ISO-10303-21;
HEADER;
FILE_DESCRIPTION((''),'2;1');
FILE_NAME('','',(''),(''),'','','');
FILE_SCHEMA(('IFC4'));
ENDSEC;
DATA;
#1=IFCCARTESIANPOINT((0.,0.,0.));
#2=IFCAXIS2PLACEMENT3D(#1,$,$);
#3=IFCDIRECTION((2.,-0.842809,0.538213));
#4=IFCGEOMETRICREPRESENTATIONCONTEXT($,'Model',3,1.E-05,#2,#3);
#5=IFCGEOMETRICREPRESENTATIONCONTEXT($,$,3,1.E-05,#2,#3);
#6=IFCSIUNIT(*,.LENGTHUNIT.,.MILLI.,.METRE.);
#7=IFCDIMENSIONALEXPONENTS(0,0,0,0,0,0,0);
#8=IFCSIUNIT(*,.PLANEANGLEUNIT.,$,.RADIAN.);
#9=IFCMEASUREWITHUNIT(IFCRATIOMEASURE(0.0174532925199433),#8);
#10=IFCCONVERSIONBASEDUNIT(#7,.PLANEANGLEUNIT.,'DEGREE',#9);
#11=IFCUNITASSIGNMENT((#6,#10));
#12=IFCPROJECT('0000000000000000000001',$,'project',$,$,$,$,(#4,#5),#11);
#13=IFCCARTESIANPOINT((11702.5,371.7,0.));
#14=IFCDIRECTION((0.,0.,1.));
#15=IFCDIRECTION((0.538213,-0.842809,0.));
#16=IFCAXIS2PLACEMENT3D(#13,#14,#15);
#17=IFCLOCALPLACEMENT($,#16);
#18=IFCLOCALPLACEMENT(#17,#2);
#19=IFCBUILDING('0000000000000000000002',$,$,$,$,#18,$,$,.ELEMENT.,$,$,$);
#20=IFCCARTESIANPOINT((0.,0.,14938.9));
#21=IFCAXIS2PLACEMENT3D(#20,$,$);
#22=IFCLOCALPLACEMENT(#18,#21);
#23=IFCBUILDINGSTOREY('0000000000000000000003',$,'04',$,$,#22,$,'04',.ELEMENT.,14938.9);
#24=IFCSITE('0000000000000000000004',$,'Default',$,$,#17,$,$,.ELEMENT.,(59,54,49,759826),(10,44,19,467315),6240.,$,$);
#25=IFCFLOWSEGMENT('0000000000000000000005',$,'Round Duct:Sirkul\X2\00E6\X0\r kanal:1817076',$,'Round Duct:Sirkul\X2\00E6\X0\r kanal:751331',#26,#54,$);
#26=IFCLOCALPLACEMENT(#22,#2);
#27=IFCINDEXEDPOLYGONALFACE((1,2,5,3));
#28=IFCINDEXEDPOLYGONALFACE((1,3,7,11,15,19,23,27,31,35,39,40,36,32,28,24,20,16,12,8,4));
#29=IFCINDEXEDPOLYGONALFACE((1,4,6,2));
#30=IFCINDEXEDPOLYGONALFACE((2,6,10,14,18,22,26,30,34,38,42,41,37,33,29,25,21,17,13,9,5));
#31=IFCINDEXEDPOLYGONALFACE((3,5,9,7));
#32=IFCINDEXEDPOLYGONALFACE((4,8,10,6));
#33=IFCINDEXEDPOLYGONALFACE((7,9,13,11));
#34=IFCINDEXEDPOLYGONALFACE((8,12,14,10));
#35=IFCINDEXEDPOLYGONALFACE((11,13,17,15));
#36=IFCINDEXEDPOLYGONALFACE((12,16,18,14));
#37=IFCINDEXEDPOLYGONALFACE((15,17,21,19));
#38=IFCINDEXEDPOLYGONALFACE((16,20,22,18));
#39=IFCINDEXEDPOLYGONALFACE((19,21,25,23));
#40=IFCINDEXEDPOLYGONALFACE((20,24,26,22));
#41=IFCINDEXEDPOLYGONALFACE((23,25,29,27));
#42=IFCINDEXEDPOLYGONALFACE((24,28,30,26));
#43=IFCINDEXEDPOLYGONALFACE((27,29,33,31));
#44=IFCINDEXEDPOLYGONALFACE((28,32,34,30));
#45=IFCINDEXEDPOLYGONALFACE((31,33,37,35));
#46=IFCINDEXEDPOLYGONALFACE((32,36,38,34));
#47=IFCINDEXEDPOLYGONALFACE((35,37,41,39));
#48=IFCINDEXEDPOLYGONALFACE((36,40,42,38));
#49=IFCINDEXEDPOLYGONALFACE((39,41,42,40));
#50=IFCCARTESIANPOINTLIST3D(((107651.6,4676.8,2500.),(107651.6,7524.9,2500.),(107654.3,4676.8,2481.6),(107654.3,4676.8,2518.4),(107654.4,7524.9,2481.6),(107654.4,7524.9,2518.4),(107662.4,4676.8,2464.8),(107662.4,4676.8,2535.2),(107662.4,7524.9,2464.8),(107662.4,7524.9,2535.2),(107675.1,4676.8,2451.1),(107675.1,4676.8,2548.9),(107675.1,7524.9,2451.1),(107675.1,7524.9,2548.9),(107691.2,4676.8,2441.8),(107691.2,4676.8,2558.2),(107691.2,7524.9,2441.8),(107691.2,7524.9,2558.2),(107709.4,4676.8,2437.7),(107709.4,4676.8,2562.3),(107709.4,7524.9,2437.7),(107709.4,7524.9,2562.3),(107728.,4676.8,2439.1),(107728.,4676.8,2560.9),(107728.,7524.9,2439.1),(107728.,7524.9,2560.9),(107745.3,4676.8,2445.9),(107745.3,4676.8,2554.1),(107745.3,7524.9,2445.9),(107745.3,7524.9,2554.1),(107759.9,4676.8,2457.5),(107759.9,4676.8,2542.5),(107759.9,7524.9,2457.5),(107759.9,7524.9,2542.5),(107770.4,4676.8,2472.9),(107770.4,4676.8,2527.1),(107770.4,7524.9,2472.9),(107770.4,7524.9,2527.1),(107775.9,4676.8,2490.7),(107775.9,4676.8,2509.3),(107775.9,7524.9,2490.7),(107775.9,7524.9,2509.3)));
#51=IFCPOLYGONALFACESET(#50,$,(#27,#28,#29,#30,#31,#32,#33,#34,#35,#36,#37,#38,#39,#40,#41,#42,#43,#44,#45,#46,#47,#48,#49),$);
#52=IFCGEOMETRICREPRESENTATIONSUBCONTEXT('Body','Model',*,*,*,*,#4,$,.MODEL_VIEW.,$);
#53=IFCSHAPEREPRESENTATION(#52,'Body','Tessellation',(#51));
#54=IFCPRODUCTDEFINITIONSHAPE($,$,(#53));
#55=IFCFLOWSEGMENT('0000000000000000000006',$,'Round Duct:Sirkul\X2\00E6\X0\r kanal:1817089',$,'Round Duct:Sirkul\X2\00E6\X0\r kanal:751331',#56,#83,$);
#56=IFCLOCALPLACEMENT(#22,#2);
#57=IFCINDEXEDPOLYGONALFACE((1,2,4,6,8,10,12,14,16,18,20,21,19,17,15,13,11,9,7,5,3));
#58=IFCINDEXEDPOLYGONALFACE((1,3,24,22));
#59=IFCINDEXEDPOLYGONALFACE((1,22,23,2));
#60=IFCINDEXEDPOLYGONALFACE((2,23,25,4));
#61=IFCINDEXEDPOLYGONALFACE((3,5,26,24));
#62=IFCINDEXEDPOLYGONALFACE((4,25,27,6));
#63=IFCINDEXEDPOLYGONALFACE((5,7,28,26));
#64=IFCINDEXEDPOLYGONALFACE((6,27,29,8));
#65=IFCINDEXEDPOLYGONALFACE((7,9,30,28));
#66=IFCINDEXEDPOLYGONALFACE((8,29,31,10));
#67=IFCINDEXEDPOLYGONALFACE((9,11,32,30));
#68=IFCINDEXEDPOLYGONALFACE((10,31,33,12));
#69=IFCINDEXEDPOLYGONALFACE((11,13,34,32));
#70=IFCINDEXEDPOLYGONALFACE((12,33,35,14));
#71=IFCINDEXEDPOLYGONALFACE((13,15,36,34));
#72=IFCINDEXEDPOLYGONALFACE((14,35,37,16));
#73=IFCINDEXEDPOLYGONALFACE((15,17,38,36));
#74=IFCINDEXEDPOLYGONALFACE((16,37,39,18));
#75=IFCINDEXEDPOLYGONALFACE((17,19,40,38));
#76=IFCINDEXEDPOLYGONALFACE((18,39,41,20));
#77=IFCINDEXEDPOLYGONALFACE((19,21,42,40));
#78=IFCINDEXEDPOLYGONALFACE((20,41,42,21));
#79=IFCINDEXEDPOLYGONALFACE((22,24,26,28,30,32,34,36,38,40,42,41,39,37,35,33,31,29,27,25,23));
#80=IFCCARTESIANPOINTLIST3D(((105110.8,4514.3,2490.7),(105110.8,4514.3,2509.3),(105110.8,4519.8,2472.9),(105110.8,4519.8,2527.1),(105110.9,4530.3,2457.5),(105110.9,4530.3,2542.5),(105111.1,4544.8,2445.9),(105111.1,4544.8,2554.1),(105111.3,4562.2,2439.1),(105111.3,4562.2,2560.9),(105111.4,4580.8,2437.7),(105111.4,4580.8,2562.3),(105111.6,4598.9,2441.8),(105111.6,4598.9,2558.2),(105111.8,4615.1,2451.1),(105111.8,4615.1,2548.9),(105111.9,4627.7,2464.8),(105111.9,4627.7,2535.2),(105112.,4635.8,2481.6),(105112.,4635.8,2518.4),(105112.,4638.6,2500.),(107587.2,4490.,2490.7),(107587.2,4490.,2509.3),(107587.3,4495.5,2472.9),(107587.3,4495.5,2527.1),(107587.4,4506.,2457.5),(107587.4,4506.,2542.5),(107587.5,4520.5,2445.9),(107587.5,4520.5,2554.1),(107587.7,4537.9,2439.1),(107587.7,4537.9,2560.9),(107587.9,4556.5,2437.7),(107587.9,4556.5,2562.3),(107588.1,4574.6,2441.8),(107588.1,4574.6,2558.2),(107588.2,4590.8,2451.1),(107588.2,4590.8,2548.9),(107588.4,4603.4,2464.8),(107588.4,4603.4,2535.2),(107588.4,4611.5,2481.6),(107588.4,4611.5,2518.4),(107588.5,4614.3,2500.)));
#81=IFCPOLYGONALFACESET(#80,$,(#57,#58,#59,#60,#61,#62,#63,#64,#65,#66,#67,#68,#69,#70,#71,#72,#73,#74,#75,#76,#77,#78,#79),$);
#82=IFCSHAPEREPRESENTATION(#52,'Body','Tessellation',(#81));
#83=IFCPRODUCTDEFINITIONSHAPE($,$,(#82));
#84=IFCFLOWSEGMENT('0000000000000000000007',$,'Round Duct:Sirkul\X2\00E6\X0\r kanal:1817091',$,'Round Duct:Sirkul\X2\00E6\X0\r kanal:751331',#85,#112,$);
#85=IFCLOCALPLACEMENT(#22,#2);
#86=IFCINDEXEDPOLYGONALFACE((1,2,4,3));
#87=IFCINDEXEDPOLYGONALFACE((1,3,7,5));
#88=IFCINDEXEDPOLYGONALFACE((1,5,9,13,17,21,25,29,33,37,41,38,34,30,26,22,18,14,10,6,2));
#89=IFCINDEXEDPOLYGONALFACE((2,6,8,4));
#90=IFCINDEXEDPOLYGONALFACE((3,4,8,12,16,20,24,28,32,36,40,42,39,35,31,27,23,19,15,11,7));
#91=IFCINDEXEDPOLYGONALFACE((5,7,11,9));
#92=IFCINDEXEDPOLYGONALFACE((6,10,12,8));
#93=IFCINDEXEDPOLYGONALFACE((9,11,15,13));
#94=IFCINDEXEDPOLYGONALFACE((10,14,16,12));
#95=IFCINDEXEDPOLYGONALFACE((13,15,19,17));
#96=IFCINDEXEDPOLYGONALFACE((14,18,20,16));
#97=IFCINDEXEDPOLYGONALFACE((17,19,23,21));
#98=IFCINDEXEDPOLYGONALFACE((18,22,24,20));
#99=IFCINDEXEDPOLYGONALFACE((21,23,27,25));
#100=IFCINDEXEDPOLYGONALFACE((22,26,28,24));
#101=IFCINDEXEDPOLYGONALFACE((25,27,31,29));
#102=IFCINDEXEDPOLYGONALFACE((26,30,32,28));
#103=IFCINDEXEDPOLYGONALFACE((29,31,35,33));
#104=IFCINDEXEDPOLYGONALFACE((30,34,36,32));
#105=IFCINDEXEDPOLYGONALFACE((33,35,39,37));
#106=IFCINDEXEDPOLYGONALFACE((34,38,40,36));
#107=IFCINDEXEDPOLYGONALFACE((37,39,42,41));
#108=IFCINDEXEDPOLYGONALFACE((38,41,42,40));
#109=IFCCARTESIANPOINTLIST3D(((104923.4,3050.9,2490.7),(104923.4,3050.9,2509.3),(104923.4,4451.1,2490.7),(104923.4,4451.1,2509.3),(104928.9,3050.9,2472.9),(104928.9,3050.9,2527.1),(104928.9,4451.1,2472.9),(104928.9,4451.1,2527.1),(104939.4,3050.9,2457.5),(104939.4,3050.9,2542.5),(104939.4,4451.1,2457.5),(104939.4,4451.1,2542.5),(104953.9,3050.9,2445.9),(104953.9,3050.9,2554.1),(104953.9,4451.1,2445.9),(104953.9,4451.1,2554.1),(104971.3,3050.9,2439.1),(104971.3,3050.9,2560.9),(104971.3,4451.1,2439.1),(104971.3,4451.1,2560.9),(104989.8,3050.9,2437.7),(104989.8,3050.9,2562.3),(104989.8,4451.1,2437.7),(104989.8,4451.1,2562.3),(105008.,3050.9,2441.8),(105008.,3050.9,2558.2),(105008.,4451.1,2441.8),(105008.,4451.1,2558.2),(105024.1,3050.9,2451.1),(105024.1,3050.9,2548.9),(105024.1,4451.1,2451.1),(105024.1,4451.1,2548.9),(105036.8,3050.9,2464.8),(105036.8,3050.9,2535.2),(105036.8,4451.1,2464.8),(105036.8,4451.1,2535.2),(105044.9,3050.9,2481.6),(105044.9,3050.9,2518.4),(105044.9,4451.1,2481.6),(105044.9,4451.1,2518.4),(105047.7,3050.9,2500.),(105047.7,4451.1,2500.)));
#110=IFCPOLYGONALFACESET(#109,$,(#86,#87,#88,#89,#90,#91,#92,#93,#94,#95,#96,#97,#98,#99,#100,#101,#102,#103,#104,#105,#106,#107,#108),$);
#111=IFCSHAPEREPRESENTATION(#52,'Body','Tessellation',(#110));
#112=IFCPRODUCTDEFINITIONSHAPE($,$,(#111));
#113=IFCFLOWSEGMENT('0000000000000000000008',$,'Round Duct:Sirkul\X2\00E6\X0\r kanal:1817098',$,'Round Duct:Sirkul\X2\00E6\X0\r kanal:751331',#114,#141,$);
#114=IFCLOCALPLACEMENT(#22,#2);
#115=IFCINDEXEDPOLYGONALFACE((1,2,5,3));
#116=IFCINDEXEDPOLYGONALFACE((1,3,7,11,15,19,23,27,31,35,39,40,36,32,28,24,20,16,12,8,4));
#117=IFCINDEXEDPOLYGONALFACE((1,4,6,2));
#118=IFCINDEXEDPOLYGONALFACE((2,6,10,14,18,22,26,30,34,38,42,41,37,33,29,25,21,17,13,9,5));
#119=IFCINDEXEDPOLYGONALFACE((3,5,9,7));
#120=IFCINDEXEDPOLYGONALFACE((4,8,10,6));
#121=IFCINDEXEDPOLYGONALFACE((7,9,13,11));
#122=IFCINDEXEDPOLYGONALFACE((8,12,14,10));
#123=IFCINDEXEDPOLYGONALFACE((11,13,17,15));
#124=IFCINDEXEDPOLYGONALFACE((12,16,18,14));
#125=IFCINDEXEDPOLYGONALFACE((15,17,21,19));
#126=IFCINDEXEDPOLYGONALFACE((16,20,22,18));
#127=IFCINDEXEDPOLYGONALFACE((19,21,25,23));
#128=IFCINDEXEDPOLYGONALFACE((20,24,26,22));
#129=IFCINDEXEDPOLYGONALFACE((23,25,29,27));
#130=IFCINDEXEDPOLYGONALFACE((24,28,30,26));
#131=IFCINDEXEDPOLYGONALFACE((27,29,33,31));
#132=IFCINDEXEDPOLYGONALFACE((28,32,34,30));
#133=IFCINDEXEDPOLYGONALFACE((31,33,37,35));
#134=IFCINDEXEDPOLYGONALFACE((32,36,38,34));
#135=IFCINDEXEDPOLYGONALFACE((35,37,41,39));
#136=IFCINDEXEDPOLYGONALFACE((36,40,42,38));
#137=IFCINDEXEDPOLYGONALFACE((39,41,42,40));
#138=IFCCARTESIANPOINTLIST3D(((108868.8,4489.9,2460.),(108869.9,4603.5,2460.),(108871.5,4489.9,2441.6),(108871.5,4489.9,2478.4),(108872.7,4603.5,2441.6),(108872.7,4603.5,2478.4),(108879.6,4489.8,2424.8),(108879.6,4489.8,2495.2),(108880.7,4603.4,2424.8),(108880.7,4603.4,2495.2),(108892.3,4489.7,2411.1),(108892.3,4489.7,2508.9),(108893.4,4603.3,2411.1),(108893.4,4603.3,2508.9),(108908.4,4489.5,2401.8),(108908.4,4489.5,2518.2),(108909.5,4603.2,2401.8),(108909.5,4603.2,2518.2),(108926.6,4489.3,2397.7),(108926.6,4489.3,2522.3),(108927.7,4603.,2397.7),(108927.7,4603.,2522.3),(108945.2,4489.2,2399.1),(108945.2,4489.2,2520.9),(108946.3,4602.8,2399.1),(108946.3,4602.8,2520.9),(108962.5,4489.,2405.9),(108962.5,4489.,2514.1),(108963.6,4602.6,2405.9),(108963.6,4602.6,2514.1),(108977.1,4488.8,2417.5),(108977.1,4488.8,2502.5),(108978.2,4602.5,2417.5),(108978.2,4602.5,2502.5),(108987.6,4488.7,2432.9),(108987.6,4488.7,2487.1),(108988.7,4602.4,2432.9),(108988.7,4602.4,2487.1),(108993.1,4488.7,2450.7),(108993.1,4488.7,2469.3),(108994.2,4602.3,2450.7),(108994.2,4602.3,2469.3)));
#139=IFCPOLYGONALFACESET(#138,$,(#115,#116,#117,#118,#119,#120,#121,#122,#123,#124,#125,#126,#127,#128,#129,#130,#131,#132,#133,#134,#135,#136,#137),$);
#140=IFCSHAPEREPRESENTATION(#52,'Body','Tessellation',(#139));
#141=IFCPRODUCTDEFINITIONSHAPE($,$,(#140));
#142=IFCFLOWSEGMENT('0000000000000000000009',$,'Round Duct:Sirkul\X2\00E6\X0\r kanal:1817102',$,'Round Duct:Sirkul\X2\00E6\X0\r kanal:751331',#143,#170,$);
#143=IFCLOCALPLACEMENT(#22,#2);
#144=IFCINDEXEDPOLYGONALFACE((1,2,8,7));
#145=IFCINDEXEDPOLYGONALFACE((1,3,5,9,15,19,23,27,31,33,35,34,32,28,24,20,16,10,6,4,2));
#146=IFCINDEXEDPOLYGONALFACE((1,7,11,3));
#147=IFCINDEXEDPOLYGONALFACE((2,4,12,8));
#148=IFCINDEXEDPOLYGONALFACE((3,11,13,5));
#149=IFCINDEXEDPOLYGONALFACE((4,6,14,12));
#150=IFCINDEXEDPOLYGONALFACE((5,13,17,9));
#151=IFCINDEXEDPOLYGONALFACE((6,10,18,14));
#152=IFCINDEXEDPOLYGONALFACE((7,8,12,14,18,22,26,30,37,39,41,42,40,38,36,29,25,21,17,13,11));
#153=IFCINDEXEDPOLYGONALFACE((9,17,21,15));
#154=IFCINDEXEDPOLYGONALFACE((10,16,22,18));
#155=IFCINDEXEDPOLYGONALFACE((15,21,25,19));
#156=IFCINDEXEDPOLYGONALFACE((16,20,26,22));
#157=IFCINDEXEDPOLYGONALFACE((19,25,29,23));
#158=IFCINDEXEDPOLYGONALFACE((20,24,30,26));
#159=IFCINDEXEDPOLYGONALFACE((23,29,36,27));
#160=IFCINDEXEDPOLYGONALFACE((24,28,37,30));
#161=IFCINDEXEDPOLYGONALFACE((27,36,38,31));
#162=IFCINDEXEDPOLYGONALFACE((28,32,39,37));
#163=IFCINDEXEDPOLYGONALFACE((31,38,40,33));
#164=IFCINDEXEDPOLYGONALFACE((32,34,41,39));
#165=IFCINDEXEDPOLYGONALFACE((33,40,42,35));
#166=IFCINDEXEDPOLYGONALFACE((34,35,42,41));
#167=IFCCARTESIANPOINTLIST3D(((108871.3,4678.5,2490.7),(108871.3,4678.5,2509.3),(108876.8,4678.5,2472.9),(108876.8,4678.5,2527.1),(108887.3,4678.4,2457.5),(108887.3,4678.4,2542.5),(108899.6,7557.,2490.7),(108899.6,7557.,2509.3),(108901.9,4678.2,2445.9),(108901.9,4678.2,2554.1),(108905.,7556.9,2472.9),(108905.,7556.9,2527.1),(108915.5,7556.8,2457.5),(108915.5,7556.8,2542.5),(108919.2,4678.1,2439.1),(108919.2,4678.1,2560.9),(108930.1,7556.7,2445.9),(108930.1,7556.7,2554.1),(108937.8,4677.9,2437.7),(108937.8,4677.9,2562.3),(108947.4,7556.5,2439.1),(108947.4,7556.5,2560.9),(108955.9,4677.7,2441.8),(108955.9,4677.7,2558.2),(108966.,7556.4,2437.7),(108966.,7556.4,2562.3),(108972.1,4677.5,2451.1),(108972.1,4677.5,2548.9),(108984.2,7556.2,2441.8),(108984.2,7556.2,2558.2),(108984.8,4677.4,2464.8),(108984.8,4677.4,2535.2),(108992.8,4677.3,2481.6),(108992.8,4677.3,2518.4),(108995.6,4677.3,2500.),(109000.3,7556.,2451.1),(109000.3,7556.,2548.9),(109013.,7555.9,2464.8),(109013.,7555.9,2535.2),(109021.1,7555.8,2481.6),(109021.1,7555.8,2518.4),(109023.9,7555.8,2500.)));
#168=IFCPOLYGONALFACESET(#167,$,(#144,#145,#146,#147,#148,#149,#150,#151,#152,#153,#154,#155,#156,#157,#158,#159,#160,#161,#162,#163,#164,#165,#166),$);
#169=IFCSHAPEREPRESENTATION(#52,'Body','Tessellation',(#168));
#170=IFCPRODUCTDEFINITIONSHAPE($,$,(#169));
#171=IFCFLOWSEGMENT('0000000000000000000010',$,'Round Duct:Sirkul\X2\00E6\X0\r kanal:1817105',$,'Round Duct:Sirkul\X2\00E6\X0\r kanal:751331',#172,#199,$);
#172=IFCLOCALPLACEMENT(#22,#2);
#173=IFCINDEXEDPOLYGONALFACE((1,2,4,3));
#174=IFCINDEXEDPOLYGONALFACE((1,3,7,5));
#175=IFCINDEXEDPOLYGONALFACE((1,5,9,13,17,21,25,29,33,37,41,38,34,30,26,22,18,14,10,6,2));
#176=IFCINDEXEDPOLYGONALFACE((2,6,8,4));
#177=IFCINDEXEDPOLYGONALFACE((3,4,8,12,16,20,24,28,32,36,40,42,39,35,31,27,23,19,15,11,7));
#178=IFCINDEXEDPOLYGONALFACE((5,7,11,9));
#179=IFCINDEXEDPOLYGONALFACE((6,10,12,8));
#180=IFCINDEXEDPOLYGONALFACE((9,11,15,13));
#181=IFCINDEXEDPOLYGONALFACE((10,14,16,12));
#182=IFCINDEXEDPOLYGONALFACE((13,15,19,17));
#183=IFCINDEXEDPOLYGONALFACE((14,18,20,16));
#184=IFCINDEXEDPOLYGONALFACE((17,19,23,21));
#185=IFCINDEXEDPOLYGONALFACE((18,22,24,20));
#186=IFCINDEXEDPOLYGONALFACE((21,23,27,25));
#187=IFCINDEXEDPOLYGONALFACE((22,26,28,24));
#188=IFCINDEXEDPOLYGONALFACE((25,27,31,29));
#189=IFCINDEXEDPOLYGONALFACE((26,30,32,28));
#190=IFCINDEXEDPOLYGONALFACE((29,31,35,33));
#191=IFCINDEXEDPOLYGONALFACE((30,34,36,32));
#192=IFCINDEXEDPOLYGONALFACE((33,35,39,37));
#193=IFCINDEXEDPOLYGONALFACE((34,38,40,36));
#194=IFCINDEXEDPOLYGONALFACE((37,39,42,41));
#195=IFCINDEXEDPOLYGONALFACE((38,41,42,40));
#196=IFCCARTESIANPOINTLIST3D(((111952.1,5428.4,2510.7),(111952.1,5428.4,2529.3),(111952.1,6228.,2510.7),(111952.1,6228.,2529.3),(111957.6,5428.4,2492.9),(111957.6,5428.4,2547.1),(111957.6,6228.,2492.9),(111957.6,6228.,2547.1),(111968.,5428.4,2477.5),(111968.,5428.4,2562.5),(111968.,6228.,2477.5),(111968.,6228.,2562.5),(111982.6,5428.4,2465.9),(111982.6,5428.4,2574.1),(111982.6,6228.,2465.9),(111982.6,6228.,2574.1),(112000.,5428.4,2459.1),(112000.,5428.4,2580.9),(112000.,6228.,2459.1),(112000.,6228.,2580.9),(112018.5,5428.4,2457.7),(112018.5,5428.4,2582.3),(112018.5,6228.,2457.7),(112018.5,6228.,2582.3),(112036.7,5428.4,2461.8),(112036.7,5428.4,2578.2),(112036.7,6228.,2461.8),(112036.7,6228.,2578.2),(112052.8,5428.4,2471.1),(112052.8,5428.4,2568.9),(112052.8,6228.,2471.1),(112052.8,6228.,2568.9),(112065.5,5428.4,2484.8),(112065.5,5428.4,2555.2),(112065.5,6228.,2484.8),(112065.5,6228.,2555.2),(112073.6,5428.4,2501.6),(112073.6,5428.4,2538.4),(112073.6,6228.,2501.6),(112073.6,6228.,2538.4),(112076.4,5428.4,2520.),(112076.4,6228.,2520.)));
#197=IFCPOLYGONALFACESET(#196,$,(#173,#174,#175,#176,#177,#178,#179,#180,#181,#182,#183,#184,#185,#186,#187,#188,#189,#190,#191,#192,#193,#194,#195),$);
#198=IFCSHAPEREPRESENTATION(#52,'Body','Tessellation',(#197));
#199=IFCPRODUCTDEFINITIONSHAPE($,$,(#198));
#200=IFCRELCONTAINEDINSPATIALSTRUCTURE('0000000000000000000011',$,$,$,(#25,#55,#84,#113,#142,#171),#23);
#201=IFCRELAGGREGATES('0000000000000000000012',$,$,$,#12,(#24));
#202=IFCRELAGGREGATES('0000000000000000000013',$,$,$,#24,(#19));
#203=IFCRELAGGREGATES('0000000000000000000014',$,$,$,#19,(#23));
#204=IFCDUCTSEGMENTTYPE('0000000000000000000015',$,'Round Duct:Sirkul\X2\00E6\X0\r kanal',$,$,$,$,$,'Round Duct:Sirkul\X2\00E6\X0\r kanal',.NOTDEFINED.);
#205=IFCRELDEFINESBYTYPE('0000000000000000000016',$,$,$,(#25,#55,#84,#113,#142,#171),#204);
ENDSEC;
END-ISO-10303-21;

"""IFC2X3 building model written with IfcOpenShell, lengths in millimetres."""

from ifc_helpers import new_model, entity, si_unit, converted_unit, direction, frame, frame_2d, origin, origin_2d_with_axis, place, context, subcontext, project, spatial, circle, extrude, type_object, element, save


model = new_model("IFC2X3")

# Units and contexts
model_context = context("Model", 3, precision=1e-05, world=origin(), true_north=direction((2.0, -0.842809, 0.538213)))
context_of_model = context(None, 3, precision=1e-05, world=origin(), true_north=direction((2.0, -0.842809, 0.538213)))
body_context = subcontext(model_context, "Body", "Model", "MODEL_VIEW")
ifc_project = project(units=[si_unit("LENGTHUNIT", "METRE", prefix="MILLI"), converted_unit("PLANEANGLEUNIT", "DEGREE", entity("IfcRatioMeasure", 0.0174532925199433), si_unit("PLANEANGLEUNIT", "RADIAN"), dimensions=[0, 0, 0, 0, 0, 0, 0])], contexts=[model_context, context_of_model])

# Site, building, storey
site_placement = place(None, frame((11702.5, 371.7, 0.0), z_axis=(0.0, 0.0, 1.0), x_axis=(0.538213, -0.842809, 0.0)))
site = spatial("IfcSite", under=ifc_project, at=site_placement, Name="Default", CompositionType="ELEMENT", RefLatitude=(59, 54, 49, 759826), RefLongitude=(10, 44, 19, 467315), RefElevation=6240.0)
building_placement = place(site_placement, origin())
building = spatial("IfcBuilding", under=site, at=building_placement, CompositionType="ELEMENT")
storey_placement = place(building_placement, frame((0.0, 0.0, 14938.9)))
storey = spatial("IfcBuildingStorey", under=building, at=storey_placement, Name="04", LongName="04", CompositionType="ELEMENT", Elevation=14938.9)

# Flow segments
duct_segment_type = type_object("IfcDuctSegmentType", Name="Round Duct:Sirkulær kanal", ElementType="Round Duct:Sirkulær kanal", PredefinedType="NOTDEFINED")
flow_segment_1_placement = place(storey_placement, origin())
element("IfcFlowSegment", 1, at=flow_segment_1_placement, inside=storey, type_object=duct_segment_type, Name="Round Duct:Sirkulær kanal:1817076", ObjectType="Round Duct:Sirkulær kanal:751331", context=body_context, shape_type="SweptSolid", body=[
    extrude(circle(Radius=62.5, at=origin_2d_with_axis()), frame((107714.1, 4676.8, 2500.0), z_axis=(0.000002, 1.0, 0.0), x_axis=(-1.0, 0.000002, 0.0)), (0.0, 0.0, 1.0), 2848.1),
])
flow_segment_2_placement = place(storey_placement, origin())
element("IfcFlowSegment", 2, at=flow_segment_2_placement, inside=storey, type_object=duct_segment_type, Name="Round Duct:Sirkulær kanal:1817089", ObjectType="Round Duct:Sirkulær kanal:751331", context=body_context, shape_type="SweptSolid", body=[
    extrude(circle(Radius=62.5, at=frame_2d((0.0, 0.0), x_axis=(1.0, 0.0))), frame((107587.8, 4551.8, 2500.0), z_axis=(-0.999952, 0.00981, 0.0), x_axis=(0.00981, 0.999952, 0.0)), (0.0, 0.0, 1.0), 2476.6),
])
flow_segment_3_placement = place(storey_placement, origin())
element("IfcFlowSegment", 3, at=flow_segment_3_placement, inside=storey, type_object=duct_segment_type, Name="Round Duct:Sirkulær kanal:1817091", ObjectType="Round Duct:Sirkulær kanal:751331", context=body_context, shape_type="SweptSolid", body=[
    extrude(circle(Radius=62.5, at=origin_2d_with_axis()), frame((104985.2, 3050.9, 2500.0), z_axis=(0.0, 1.0, 0.0), x_axis=(1.0, 0.0, 0.0)), (0.0, 0.0, 1.0), 1400.2),
])
flow_segment_4_placement = place(storey_placement, origin())
element("IfcFlowSegment", 4, at=flow_segment_4_placement, inside=storey, type_object=duct_segment_type, Name="Round Duct:Sirkulær kanal:1817098", ObjectType="Round Duct:Sirkulær kanal:751331", context=body_context, shape_type="SweptSolid", body=[
    extrude(circle(Radius=62.5, at=origin_2d_with_axis()), frame((108931.3, 4489.3, 2460.0), z_axis=(0.00981, 0.999952, 0.0), x_axis=(-0.999952, 0.00981, 0.0)), (0.0, 0.0, 1.0), 113.7),
])
flow_segment_5_placement = place(storey_placement, origin())
element("IfcFlowSegment", 5, at=flow_segment_5_placement, inside=storey, type_object=duct_segment_type, Name="Round Duct:Sirkulær kanal:1817102", ObjectType="Round Duct:Sirkulær kanal:751331", context=body_context, shape_type="SweptSolid", body=[
    extrude(circle(Radius=62.5, at=origin_2d_with_axis()), frame((108933.1, 4677.9, 2500.0), z_axis=(0.00981, 0.999952, 0.0), x_axis=(0.999952, -0.00981, 0.0)), (0.0, 0.0, 1.0), 2878.6),
])
flow_segment_6_placement = place(storey_placement, origin())
element("IfcFlowSegment", 6, at=flow_segment_6_placement, inside=storey, type_object=duct_segment_type, Name="Round Duct:Sirkulær kanal:1817105", ObjectType="Round Duct:Sirkulær kanal:751331", context=body_context, shape_type="SweptSolid", body=[
    extrude(circle(Radius=62.5, at=frame_2d((0.0, 0.0), x_axis=(1.0, 0.0))), frame((112013.9, 5428.4, 2520.0), z_axis=(0.000003, 1.0, 0.0), x_axis=(1.0, -0.000003, 0.0)), (0.0, 0.0, 1.0), 799.6),
])

save(model, "model.ifc")
